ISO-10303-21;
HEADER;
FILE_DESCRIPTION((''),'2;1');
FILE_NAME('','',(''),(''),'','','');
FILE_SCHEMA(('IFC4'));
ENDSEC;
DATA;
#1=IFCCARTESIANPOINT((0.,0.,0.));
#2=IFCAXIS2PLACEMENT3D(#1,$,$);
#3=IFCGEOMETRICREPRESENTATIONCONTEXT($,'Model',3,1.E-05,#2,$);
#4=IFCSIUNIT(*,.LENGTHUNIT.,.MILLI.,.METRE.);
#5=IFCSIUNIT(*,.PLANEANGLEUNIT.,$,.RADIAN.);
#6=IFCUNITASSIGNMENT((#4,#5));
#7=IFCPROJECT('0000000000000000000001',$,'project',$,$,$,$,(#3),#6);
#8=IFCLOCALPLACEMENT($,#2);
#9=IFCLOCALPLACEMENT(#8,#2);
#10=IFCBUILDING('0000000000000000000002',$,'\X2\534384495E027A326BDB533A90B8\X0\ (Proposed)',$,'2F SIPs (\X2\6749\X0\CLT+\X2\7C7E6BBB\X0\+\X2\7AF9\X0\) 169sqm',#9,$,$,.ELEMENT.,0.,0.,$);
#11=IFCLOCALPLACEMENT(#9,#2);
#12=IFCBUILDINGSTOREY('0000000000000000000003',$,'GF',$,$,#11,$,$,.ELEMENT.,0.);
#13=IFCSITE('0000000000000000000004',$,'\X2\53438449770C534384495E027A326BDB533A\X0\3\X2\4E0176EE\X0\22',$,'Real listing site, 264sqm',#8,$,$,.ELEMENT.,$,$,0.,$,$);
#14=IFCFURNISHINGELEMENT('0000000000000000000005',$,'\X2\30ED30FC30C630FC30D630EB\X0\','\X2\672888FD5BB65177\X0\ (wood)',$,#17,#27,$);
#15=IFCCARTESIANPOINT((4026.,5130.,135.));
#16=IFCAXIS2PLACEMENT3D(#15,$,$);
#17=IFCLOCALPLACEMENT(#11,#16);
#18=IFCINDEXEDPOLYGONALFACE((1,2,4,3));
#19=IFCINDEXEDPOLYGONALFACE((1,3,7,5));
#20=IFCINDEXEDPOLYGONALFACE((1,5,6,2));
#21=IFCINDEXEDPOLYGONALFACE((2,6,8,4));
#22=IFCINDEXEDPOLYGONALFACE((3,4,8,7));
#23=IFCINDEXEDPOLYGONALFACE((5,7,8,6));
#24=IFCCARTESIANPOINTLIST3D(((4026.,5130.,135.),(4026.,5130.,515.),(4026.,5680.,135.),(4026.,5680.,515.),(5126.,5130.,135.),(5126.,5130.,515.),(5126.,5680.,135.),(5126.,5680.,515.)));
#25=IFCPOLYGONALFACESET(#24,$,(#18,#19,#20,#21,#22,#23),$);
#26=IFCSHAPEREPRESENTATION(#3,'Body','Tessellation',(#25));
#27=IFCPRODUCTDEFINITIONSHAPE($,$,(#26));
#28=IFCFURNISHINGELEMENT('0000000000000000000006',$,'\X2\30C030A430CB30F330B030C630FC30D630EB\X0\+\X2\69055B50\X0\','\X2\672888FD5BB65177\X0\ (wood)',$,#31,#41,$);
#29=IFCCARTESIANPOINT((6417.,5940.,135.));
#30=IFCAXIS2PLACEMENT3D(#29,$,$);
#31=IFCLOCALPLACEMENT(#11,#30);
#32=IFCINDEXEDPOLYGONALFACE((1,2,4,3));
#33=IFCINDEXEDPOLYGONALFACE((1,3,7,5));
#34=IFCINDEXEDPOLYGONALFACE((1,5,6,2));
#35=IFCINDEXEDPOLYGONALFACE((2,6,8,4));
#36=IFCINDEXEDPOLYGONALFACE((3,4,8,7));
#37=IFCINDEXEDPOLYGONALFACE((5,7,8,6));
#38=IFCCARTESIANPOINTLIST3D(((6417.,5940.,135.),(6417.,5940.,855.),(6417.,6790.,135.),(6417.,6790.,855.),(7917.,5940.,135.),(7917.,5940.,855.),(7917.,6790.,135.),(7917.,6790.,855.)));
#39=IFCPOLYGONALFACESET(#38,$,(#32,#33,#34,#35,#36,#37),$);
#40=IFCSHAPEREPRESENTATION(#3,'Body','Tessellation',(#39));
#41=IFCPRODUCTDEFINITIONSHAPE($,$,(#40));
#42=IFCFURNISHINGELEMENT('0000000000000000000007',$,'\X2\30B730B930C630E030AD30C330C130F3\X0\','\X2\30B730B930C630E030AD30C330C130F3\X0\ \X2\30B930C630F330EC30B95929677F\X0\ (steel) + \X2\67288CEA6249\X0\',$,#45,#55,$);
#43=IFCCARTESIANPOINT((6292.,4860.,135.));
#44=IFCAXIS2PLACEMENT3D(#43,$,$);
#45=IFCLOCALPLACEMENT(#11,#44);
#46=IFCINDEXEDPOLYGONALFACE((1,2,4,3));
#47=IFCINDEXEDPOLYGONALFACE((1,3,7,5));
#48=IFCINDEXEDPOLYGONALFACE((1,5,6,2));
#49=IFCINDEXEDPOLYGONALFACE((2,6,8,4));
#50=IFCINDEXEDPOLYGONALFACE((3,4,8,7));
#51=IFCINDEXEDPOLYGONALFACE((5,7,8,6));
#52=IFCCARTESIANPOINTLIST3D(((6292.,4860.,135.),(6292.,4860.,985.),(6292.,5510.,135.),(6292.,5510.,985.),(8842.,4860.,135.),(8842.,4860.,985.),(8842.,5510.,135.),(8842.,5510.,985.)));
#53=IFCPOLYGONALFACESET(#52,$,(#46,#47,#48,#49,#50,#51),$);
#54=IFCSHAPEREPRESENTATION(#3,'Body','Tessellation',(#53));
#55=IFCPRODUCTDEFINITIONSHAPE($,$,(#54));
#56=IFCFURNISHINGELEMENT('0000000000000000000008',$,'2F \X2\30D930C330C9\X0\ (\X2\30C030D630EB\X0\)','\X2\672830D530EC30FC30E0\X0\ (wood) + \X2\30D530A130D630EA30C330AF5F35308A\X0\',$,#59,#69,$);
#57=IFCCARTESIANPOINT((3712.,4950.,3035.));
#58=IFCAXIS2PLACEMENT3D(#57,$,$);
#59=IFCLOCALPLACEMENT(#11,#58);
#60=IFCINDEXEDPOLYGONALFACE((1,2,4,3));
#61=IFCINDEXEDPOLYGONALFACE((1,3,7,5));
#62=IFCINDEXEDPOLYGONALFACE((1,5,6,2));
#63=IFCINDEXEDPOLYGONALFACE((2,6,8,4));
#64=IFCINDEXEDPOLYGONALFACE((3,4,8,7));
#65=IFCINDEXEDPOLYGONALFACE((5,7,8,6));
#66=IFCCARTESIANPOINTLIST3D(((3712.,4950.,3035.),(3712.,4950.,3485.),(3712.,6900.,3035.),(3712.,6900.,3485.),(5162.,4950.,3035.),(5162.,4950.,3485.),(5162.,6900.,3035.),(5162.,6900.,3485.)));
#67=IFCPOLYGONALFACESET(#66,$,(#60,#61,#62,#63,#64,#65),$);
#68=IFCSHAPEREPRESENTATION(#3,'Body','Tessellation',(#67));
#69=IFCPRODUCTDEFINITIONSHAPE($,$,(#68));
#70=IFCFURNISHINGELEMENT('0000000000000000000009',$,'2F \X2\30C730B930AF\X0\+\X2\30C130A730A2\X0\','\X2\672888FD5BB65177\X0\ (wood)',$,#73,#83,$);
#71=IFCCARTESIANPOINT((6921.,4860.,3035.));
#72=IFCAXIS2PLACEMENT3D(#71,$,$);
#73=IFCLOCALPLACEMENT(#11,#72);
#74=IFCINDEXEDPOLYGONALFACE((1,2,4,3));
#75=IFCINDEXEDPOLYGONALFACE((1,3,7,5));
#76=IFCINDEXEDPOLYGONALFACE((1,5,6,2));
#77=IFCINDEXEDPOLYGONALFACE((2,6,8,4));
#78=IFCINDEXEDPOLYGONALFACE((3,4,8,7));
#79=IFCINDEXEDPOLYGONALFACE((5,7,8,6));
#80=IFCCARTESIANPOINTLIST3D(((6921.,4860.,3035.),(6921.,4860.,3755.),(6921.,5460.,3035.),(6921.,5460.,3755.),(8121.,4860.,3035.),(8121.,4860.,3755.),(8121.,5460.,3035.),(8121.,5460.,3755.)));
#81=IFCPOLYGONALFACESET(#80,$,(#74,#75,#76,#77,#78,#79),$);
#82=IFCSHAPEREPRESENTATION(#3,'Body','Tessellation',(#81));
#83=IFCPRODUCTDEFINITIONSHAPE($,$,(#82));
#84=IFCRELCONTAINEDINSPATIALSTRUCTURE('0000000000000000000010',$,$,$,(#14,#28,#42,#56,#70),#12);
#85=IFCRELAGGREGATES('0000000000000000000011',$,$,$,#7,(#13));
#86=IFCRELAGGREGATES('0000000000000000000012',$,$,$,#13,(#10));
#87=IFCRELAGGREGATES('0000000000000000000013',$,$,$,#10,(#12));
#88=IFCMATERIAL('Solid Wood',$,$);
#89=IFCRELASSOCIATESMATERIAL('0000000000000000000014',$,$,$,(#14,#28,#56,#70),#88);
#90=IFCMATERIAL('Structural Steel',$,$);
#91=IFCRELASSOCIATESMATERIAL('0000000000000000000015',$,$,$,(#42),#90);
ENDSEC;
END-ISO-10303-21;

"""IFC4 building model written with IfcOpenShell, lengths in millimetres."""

from ifc_helpers import new_model, si_unit, frame, frame_2d, origin, place, context, project, spatial, rectangle, extrude, material, element, save


model = new_model("IFC4")

# Units and contexts
model_context = context("Model", 3, precision=1e-05, world=origin())
ifc_project = project(units=[si_unit("LENGTHUNIT", "METRE", prefix="MILLI"), si_unit("PLANEANGLEUNIT", "RADIAN")], contexts=[model_context])

# Site, building, storey
site_placement = place(None, origin())
site = spatial("IfcSite", under=ifc_project, at=site_placement, Name="千葉県千葉市稲毛区3丁目22", ObjectType="Real listing site, 264sqm", CompositionType="ELEMENT", RefElevation=0.0)
building_placement = place(site_placement, origin())
building = spatial("IfcBuilding", under=site, at=building_placement, Name="千葉市稲毛区邸 (Proposed)", ObjectType="2F SIPs (杉CLT+籾殻+竹) 169sqm", CompositionType="ELEMENT", ElevationOfRefHeight=0.0, ElevationOfTerrain=0.0)
storey_placement = place(building_placement, origin())
storey = spatial("IfcBuildingStorey", under=building, at=storey_placement, Name="GF", CompositionType="ELEMENT", Elevation=0.0)

# Shared definitions
ifc_material_1 = material(Name="Solid Wood")

# Shared definitions
ifc_material_2 = material(Name="Structural Steel")

# Furnishing elements
furnishing_1_placement = place(storey_placement, frame((4026.0, 5130.0, 135.0)))
element("IfcFurnishingElement", 1, at=furnishing_1_placement, inside=storey, material=ifc_material_1, Name="ローテーブル", Description="木製家具 (wood)", context=model_context, shape_type="SweptSolid", body=[
    extrude(rectangle(XDim=1100.0, YDim=550.0, at=frame_2d((550.0, 275.0))), frame((4026.0, 5130.0, 135.0)), (0.0, 0.0, 1.0), 380.0),
])
furnishing_2_placement = place(storey_placement, frame((6417.0, 5940.0, 135.0)))
element("IfcFurnishingElement", 2, at=furnishing_2_placement, inside=storey, material=ifc_material_1, Name="ダイニングテーブル+椅子", Description="木製家具 (wood)", context=model_context, shape_type="SweptSolid", body=[
    extrude(rectangle(XDim=1500.0, YDim=850.0, at=frame_2d((750.0, 425.0))), frame((6417.0, 5940.0, 135.0)), (0.0, 0.0, 1.0), 720.0),
])
furnishing_3_placement = place(storey_placement, frame((6292.0, 4860.0, 135.0)))
element("IfcFurnishingElement", 3, at=furnishing_3_placement, inside=storey, material=ifc_material_2, Name="システムキッチン", Description="システムキッチン ステンレス天板 (steel) + 木質扉", context=model_context, shape_type="SweptSolid", body=[
    extrude(rectangle(XDim=2550.0, YDim=650.0, at=frame_2d((1275.0, 325.0))), frame((6292.0, 4860.0, 135.0)), (0.0, 0.0, 1.0), 850.0),
])
furnishing_4_placement = place(storey_placement, frame((3712.0, 4950.0, 3035.0)))
element("IfcFurnishingElement", 4, at=furnishing_4_placement, inside=storey, material=ifc_material_1, Name="2F ベッド (ダブル)", Description="木フレーム (wood) + ファブリック張り", context=model_context, shape_type="SweptSolid", body=[
    extrude(rectangle(XDim=1450.0, YDim=1950.0, at=frame_2d((725.0, 975.0))), frame((3712.0, 4950.0, 3035.0)), (0.0, 0.0, 1.0), 450.0),
])
furnishing_5_placement = place(storey_placement, frame((6921.0, 4860.0, 3035.0)))
element("IfcFurnishingElement", 5, at=furnishing_5_placement, inside=storey, material=ifc_material_1, Name="2F デスク+チェア", Description="木製家具 (wood)", context=model_context, shape_type="SweptSolid", body=[
    extrude(rectangle(XDim=1200.0, YDim=600.0, at=frame_2d((600.0, 300.0))), frame((6921.0, 4860.0, 3035.0)), (0.0, 0.0, 1.0), 720.0),
])

save(model, "model.ifc")
